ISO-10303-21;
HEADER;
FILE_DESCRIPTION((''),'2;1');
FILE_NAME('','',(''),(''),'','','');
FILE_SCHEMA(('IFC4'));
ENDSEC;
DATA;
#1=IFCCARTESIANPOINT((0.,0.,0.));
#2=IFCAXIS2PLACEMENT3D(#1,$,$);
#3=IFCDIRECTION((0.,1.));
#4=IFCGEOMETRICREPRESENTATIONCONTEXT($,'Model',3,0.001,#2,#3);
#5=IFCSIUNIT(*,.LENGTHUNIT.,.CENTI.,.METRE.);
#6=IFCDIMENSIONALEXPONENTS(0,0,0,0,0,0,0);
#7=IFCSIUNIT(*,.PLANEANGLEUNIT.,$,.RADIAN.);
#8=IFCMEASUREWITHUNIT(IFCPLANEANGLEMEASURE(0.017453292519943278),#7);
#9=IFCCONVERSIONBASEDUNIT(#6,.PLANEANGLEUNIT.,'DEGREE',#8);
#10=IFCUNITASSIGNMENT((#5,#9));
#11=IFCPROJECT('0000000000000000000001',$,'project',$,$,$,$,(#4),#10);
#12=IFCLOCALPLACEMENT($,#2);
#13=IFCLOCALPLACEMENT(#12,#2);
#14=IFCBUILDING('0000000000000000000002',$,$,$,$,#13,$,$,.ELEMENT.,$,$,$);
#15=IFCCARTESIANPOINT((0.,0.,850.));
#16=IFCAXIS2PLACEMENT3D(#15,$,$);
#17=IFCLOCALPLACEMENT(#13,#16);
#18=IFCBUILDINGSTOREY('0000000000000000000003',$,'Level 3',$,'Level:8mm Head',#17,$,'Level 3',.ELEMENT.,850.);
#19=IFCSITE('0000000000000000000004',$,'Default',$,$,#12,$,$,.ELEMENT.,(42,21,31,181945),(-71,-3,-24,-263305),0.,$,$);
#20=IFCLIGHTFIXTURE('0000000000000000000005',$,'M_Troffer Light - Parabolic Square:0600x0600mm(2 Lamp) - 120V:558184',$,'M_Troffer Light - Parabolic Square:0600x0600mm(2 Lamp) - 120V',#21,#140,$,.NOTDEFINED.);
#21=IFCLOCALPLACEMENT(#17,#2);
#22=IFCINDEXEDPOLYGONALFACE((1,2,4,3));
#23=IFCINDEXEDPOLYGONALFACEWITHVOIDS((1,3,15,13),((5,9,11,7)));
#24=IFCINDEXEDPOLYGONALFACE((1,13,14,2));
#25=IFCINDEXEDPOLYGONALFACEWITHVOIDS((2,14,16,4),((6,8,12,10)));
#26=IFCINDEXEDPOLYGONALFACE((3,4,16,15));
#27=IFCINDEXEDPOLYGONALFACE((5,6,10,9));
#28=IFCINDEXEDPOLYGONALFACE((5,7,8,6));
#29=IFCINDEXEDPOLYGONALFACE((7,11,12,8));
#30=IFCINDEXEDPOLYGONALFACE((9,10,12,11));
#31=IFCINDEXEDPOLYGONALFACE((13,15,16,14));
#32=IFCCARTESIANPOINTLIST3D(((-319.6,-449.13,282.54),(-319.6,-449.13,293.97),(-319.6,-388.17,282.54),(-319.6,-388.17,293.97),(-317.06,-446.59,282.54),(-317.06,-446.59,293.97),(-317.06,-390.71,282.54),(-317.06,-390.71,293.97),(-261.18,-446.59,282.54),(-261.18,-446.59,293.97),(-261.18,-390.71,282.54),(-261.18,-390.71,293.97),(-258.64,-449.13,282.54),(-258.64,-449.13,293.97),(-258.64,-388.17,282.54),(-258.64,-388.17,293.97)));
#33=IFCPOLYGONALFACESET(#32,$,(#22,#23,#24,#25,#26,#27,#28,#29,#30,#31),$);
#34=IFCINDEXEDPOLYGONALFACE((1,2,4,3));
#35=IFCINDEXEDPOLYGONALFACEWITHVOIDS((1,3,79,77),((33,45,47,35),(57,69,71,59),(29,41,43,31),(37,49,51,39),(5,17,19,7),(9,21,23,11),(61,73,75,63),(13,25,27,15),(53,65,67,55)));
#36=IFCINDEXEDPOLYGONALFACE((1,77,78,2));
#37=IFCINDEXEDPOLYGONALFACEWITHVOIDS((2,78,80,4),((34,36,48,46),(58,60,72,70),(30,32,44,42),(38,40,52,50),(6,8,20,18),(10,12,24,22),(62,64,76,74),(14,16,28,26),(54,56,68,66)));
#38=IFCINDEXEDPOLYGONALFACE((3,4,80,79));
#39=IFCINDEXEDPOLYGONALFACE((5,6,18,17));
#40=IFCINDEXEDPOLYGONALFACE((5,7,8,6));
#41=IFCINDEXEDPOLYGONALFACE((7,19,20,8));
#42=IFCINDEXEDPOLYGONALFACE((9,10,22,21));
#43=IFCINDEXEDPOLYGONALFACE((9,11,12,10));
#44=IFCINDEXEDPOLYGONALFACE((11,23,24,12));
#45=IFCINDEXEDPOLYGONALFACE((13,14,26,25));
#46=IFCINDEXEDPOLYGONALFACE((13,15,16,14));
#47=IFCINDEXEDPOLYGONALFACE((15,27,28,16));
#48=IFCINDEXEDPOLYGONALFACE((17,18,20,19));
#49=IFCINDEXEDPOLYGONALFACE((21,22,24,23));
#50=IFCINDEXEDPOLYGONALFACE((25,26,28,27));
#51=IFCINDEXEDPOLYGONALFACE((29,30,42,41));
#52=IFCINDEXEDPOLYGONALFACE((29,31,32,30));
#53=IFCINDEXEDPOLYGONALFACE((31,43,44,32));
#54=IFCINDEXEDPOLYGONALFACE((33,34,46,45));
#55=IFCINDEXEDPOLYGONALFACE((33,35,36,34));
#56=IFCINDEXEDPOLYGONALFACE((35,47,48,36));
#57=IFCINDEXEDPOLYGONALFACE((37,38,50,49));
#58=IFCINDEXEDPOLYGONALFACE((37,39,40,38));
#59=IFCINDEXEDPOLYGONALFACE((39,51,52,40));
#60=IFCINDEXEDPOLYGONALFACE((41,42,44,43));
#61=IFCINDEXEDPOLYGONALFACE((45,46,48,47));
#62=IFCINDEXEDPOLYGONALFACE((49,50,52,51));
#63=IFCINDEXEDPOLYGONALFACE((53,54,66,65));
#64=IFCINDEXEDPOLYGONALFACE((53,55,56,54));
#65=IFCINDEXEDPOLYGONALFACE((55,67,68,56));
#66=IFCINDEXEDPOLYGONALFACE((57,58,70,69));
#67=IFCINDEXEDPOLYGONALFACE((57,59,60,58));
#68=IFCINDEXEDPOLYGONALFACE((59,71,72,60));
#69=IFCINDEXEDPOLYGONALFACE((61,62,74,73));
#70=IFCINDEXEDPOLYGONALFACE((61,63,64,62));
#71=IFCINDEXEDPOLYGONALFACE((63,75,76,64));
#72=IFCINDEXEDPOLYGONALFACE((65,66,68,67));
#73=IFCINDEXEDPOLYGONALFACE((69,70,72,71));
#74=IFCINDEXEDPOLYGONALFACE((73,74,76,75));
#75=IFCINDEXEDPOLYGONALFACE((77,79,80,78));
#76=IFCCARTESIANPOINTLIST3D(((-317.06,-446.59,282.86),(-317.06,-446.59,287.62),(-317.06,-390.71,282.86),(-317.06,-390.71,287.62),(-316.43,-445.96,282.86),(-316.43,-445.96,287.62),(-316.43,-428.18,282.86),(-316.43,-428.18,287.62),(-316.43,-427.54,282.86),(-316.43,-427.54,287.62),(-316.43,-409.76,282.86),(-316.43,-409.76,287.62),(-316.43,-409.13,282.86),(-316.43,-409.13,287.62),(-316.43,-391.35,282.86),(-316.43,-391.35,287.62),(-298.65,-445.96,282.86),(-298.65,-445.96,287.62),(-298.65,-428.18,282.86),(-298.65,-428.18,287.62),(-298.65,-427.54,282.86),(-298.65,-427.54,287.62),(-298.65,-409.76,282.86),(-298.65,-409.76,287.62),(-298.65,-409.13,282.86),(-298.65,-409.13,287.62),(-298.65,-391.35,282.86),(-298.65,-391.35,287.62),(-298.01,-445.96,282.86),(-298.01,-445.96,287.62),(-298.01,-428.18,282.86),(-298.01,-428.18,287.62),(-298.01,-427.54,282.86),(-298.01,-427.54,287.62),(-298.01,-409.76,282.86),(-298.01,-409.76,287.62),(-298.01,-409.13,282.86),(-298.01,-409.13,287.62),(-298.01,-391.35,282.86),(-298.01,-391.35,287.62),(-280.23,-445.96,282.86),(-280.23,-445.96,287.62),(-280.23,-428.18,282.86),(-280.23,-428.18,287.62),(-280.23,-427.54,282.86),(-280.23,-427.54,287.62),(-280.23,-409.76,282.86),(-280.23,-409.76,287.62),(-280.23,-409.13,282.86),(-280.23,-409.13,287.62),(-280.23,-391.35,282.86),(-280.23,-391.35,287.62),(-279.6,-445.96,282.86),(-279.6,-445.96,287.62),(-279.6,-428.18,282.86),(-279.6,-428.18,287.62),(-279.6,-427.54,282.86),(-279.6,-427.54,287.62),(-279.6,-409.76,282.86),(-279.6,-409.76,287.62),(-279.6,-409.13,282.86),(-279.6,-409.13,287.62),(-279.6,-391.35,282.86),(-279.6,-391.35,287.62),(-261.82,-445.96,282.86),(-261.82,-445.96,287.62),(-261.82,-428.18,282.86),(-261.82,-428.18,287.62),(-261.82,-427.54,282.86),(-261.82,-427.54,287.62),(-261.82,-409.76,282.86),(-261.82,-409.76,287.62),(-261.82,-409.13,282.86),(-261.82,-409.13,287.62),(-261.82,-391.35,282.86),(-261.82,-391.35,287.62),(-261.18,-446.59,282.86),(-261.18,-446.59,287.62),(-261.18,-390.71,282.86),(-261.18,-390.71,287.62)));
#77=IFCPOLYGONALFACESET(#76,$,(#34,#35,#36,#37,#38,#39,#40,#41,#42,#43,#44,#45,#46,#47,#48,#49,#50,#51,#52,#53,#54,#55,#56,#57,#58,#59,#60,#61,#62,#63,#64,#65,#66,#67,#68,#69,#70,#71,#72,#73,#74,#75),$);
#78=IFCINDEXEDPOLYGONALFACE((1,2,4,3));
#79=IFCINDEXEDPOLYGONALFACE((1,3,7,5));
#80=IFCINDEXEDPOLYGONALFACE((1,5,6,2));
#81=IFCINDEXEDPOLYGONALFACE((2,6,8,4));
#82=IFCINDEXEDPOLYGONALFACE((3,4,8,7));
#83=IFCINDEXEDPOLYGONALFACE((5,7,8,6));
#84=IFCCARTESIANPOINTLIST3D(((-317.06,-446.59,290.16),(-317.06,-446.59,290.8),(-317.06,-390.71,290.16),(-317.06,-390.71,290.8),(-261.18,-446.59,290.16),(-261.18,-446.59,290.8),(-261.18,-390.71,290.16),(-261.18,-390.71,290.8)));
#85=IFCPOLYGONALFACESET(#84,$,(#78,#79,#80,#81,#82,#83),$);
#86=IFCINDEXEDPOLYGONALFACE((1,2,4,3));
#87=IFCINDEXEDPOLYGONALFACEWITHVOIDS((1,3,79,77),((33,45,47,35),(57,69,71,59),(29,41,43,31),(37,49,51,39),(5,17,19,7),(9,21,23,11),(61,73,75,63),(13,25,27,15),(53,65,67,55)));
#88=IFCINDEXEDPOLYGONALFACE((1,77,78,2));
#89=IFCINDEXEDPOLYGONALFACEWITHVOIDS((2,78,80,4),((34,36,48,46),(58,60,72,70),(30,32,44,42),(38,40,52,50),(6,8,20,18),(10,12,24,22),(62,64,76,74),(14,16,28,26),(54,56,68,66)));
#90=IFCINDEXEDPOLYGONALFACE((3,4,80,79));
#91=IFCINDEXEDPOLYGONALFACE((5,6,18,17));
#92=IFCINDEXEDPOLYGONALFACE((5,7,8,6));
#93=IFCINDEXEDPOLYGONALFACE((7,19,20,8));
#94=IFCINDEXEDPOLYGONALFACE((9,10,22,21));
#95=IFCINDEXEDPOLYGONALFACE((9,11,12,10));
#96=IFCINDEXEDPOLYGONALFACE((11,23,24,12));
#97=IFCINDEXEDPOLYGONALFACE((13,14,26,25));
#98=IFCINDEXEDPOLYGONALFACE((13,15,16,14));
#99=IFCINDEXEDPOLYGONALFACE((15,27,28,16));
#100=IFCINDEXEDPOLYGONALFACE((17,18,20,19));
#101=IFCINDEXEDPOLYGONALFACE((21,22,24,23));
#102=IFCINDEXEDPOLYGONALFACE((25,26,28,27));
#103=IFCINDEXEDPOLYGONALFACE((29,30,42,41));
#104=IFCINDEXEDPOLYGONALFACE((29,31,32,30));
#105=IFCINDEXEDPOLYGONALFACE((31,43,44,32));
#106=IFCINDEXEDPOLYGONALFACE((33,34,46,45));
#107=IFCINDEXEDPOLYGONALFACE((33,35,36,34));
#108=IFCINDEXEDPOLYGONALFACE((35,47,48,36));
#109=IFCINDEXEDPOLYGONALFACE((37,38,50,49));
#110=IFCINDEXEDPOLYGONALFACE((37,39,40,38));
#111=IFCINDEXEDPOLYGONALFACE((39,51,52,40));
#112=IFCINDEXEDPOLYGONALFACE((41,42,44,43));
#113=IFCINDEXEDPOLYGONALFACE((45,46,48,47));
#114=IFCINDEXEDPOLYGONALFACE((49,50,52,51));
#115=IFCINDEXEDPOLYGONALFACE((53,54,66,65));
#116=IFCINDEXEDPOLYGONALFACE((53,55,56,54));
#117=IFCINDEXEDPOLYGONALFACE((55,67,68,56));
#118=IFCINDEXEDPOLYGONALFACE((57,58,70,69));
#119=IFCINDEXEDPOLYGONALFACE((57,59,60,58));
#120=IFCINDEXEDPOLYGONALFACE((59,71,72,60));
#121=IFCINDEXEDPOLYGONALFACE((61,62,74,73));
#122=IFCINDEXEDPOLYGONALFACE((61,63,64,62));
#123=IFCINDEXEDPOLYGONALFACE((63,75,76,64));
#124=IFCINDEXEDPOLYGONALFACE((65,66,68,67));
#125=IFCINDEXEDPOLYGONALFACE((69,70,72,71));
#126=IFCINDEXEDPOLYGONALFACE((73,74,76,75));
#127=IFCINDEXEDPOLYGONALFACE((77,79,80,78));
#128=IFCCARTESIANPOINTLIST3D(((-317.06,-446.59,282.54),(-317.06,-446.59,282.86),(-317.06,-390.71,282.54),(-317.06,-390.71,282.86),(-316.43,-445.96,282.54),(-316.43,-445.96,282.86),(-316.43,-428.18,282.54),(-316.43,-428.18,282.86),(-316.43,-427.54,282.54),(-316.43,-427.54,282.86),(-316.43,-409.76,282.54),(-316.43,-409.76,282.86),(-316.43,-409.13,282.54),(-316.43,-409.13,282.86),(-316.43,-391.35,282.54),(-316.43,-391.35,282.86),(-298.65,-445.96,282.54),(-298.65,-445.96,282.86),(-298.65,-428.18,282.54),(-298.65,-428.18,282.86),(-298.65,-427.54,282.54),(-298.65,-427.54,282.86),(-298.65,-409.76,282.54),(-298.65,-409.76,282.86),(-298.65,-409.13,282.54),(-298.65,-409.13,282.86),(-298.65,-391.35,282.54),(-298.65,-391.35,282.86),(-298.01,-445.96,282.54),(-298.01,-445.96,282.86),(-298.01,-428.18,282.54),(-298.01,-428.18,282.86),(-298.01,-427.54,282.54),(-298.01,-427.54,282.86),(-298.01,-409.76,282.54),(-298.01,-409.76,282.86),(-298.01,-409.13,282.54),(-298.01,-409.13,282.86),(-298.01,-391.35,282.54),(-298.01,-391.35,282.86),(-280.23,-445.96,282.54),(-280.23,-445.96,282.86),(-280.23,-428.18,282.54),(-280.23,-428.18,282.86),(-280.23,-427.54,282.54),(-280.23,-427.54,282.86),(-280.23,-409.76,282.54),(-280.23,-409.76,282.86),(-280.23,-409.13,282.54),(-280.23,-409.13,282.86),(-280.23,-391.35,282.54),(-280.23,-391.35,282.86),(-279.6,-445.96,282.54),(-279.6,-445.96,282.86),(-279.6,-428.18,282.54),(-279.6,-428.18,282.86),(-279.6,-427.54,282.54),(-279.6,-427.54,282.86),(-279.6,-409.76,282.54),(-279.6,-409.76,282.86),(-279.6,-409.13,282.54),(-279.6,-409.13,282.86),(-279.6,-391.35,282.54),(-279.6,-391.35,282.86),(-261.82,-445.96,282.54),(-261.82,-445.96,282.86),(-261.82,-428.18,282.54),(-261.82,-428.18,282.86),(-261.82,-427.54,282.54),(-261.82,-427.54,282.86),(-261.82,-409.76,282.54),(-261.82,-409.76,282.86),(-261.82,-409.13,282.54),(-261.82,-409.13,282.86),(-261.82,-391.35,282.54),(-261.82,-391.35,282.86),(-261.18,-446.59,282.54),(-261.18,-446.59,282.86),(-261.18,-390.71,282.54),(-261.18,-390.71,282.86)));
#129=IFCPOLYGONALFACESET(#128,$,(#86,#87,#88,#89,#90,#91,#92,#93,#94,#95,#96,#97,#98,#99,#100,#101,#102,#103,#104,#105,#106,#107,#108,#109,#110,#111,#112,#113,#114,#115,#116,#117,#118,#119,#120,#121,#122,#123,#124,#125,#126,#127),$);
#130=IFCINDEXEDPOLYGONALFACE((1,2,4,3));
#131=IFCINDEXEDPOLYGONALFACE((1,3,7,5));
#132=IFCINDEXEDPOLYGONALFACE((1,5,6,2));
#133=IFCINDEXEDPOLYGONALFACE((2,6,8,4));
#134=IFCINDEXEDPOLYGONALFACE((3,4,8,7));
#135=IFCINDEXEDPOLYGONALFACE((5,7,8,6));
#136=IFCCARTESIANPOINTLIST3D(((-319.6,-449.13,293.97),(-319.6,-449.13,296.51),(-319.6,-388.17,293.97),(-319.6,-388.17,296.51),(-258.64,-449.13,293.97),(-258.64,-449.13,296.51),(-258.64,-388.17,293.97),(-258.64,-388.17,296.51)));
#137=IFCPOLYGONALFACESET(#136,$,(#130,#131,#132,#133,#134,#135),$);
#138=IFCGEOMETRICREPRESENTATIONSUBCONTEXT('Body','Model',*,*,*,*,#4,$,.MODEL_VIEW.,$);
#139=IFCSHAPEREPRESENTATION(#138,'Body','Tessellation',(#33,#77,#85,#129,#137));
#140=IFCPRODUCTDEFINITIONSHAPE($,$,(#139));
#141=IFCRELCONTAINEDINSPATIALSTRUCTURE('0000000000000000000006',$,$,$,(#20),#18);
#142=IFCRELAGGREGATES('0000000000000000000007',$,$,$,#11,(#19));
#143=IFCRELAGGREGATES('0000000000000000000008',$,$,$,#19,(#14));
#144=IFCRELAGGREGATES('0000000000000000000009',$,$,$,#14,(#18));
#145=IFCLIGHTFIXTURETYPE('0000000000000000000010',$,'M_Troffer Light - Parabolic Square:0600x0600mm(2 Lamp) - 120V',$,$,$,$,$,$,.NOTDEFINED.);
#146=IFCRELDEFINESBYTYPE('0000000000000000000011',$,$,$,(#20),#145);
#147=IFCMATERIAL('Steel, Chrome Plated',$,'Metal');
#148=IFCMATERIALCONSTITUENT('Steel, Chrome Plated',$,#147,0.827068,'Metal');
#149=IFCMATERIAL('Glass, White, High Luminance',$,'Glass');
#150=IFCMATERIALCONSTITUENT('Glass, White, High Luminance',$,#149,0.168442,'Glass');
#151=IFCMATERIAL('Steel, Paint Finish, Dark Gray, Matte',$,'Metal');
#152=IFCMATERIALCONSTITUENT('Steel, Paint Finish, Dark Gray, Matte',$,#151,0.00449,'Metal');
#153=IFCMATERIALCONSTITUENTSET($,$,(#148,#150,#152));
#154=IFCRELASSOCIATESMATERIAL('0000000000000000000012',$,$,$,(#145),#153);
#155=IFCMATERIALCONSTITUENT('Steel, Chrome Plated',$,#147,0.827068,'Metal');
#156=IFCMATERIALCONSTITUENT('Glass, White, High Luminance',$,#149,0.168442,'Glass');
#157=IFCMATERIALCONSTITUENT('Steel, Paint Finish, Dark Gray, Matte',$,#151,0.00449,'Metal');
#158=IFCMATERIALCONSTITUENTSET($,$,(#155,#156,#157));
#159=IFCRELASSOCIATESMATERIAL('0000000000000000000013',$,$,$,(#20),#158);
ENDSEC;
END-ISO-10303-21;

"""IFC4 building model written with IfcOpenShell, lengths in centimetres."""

from ifc_helpers import new_model, entity, si_unit, converted_unit, direction, frame, origin, place, context, subcontext, project, spatial, indexed_curve, outline, extrude, source, transform, mapped, material, constituent, constituent_set, type_object, type_shapes, element, save


model = new_model("IFC4")

# Units and contexts
model_context = context("Model", 3, precision=0.001, world=origin(), true_north=direction((0.0, 1.0)))
body_context = subcontext(model_context, "Body", "Model", "MODEL_VIEW")
ifc_project = project(units=[si_unit("LENGTHUNIT", "METRE", prefix="CENTI"), converted_unit("PLANEANGLEUNIT", "DEGREE", entity("IfcPlaneAngleMeasure", 0.017453292519943278), si_unit("PLANEANGLEUNIT", "RADIAN"), dimensions=[0, 0, 0, 0, 0, 0, 0])], contexts=[model_context])

# Site, building, storey
site_placement = place(None, origin())
site = spatial("IfcSite", under=ifc_project, at=site_placement, Name="Default", CompositionType="ELEMENT", RefLatitude=(42, 21, 31, 181945), RefLongitude=(-71, -3, -24, -263305), RefElevation=0.0)
building_placement = place(site_placement, origin())
building = spatial("IfcBuilding", under=site, at=building_placement, CompositionType="ELEMENT")
storey_placement = place(building_placement, frame((0.0, 0.0, 850.0)))
storey = spatial("IfcBuildingStorey", under=building, at=storey_placement, Name="Level 3", ObjectType="Level:8mm Head", LongName="Level 3", CompositionType="ELEMENT", Elevation=850.0)

# Light fixture
ifc_material_1 = material(Name="Steel, Chrome Plated", Category="Metal")
ifc_material_2 = material(Name="Glass, White, High Luminance", Category="Glass")
ifc_material_3 = material(Name="Steel, Paint Finish, Dark Gray, Matte", Category="Metal")
ifc_constituent_1 = constituent(ifc_material_1, Name="Steel, Chrome Plated", Category="Metal", fraction=0.827068)
ifc_constituent_2 = constituent(ifc_material_2, Name="Glass, White, High Luminance", Category="Glass", fraction=0.168442)
ifc_constituent_3 = constituent(ifc_material_3, Name="Steel, Paint Finish, Dark Gray, Matte", Category="Metal", fraction=0.00449)
ifc_constituent_set_1 = constituent_set(constituents=[ifc_constituent_1, ifc_constituent_2, ifc_constituent_3])
light_fixture_type_1 = type_object("IfcLightFixtureType", Name="M_Troffer Light - Parabolic Square:0600x0600mm(2 Lamp) - 120V", PredefinedType="NOTDEFINED", material=ifc_constituent_set_1)
shared_shape_1 = source(origin(), body_context, "Body", "SweptSolid", [
    extrude(outline(indexed_curve([(-30.48, -30.48), (30.48, -30.48), (30.48, 30.48), (-30.48, 30.48), (-30.48, -30.48)], self_intersect=False), holes=[indexed_curve([(-27.94, -27.94), (-27.94, 27.94), (27.94, 27.94), (27.94, -27.94), (-27.94, -27.94)], self_intersect=False)]), frame((-1.87, -5.95, 243.84), z_axis=(0.0, 0.0, 1.0), x_axis=(-1.0, 0.0, 0.0)), (0.0, 0.0, 1.0), 11.43),
    extrude(outline(indexed_curve([(-27.94, -27.94), (27.94, -27.94), (27.94, 27.94), (-27.94, 27.94), (-27.94, -27.94)], self_intersect=False), holes=[indexed_curve([(9.52, -9.52), (27.31, -9.52), (27.31, -27.3), (9.52, -27.3), (9.52, -9.52)], self_intersect=False), indexed_curve([(9.52, 8.89), (27.3, 8.89), (27.3, -8.89), (9.52, -8.89), (9.52, 8.89)], self_intersect=False), indexed_curve([(9.52, 9.53), (9.52, 27.31), (27.3, 27.31), (27.3, 9.53), (9.52, 9.53)], self_intersect=False), indexed_curve([(-8.89, -9.52), (8.89, -9.52), (8.89, -27.3), (-8.89, -27.3), (-8.89, -9.52)], self_intersect=False), indexed_curve([(-8.89, 8.89), (8.89, 8.89), (8.89, -8.89), (-8.89, -8.89), (-8.89, 8.89)], self_intersect=False), indexed_curve([(-8.89, 9.53), (-8.89, 27.31), (8.89, 27.31), (8.89, 9.53), (-8.89, 9.53)], self_intersect=False), indexed_curve([(-27.31, -9.52), (-9.53, -9.52), (-9.53, -27.31), (-27.31, -27.31), (-27.31, -9.52)], self_intersect=False), indexed_curve([(-27.31, 8.89), (-9.52, 8.89), (-9.52, -8.89), (-27.31, -8.89), (-27.31, 8.89)], self_intersect=False), indexed_curve([(-27.31, 9.53), (-27.31, 27.31), (-9.52, 27.31), (-9.52, 9.53), (-27.31, 9.53)], self_intersect=False)]), frame((-1.87, -5.95, 244.16), z_axis=(0.0, 0.0, 1.0), x_axis=(-1.0, 0.0, 0.0)), (0.0, 0.0, 1.0), 4.76),
    extrude(outline(indexed_curve([(-27.94, -27.94), (27.94, -27.94), (27.94, 27.94), (-27.94, 27.94), (-27.94, -27.94)], self_intersect=False)), frame((-1.87, -5.95, 251.46), z_axis=(0.0, 0.0, 1.0), x_axis=(-1.0, 0.0, 0.0)), (0.0, 0.0, 1.0), 0.64),
    extrude(outline(indexed_curve([(-27.94, -27.94), (27.94, -27.94), (27.94, 27.94), (-27.94, 27.94), (-27.94, -27.94)], self_intersect=False), holes=[indexed_curve([(9.52, -9.52), (27.31, -9.52), (27.31, -27.3), (9.52, -27.3), (9.52, -9.52)], self_intersect=False), indexed_curve([(9.52, 8.89), (27.3, 8.89), (27.3, -8.89), (9.52, -8.89), (9.52, 8.89)], self_intersect=False), indexed_curve([(9.52, 9.53), (9.52, 27.31), (27.3, 27.31), (27.3, 9.53), (9.52, 9.53)], self_intersect=False), indexed_curve([(-8.89, -9.52), (8.89, -9.52), (8.89, -27.3), (-8.89, -27.3), (-8.89, -9.52)], self_intersect=False), indexed_curve([(-8.89, 8.89), (8.89, 8.89), (8.89, -8.89), (-8.89, -8.89), (-8.89, 8.89)], self_intersect=False), indexed_curve([(-8.89, 9.53), (-8.89, 27.31), (8.89, 27.31), (8.89, 9.53), (-8.89, 9.53)], self_intersect=False), indexed_curve([(-27.31, -9.52), (-9.53, -9.52), (-9.53, -27.31), (-27.31, -27.31), (-27.31, -9.52)], self_intersect=False), indexed_curve([(-27.31, 8.89), (-9.52, 8.89), (-9.52, -8.89), (-27.31, -8.89), (-27.31, 8.89)], self_intersect=False), indexed_curve([(-27.31, 9.53), (-27.31, 27.31), (-9.52, 27.31), (-9.52, 9.53), (-27.31, 9.53)], self_intersect=False)]), frame((-1.87, -5.95, 243.84), z_axis=(0.0, 0.0, 1.0), x_axis=(-1.0, 0.0, 0.0)), (0.0, 0.0, 1.0), 0.32),
    extrude(outline(indexed_curve([(-30.48, -30.48), (30.48, -30.48), (30.48, 30.48), (-30.48, 30.48), (-30.48, -30.48)], self_intersect=False)), frame((-1.87, -5.95, 255.27), z_axis=(0.0, 0.0, 1.0), x_axis=(-1.0, 0.0, 0.0)), (0.0, 0.0, 1.0), 2.54),
])
type_shapes(light_fixture_type_1, [shared_shape_1])
ifc_constituent_4 = constituent(ifc_material_1, Name="Steel, Chrome Plated", Category="Metal", fraction=0.827068)
ifc_constituent_5 = constituent(ifc_material_2, Name="Glass, White, High Luminance", Category="Glass", fraction=0.168442)
ifc_constituent_6 = constituent(ifc_material_3, Name="Steel, Paint Finish, Dark Gray, Matte", Category="Metal", fraction=0.00449)
ifc_constituent_set_2 = constituent_set(constituents=[ifc_constituent_4, ifc_constituent_5, ifc_constituent_6])
light_fixture_1_placement = place(storey_placement, frame((-287.25, -412.71, 38.7)))
element("IfcLightFixture", 1, at=light_fixture_1_placement, inside=storey, type_object=light_fixture_type_1, material=ifc_constituent_set_2, Name="M_Troffer Light - Parabolic Square:0600x0600mm(2 Lamp) - 120V:558184", ObjectType="M_Troffer Light - Parabolic Square:0600x0600mm(2 Lamp) - 120V", PredefinedType="NOTDEFINED", context=body_context, shape_type="MappedRepresentation", body=[
    mapped(shared_shape_1, transform((0.0, 0.0, 0.0), scale=1.0)),
])

save(model, "model.ifc")
